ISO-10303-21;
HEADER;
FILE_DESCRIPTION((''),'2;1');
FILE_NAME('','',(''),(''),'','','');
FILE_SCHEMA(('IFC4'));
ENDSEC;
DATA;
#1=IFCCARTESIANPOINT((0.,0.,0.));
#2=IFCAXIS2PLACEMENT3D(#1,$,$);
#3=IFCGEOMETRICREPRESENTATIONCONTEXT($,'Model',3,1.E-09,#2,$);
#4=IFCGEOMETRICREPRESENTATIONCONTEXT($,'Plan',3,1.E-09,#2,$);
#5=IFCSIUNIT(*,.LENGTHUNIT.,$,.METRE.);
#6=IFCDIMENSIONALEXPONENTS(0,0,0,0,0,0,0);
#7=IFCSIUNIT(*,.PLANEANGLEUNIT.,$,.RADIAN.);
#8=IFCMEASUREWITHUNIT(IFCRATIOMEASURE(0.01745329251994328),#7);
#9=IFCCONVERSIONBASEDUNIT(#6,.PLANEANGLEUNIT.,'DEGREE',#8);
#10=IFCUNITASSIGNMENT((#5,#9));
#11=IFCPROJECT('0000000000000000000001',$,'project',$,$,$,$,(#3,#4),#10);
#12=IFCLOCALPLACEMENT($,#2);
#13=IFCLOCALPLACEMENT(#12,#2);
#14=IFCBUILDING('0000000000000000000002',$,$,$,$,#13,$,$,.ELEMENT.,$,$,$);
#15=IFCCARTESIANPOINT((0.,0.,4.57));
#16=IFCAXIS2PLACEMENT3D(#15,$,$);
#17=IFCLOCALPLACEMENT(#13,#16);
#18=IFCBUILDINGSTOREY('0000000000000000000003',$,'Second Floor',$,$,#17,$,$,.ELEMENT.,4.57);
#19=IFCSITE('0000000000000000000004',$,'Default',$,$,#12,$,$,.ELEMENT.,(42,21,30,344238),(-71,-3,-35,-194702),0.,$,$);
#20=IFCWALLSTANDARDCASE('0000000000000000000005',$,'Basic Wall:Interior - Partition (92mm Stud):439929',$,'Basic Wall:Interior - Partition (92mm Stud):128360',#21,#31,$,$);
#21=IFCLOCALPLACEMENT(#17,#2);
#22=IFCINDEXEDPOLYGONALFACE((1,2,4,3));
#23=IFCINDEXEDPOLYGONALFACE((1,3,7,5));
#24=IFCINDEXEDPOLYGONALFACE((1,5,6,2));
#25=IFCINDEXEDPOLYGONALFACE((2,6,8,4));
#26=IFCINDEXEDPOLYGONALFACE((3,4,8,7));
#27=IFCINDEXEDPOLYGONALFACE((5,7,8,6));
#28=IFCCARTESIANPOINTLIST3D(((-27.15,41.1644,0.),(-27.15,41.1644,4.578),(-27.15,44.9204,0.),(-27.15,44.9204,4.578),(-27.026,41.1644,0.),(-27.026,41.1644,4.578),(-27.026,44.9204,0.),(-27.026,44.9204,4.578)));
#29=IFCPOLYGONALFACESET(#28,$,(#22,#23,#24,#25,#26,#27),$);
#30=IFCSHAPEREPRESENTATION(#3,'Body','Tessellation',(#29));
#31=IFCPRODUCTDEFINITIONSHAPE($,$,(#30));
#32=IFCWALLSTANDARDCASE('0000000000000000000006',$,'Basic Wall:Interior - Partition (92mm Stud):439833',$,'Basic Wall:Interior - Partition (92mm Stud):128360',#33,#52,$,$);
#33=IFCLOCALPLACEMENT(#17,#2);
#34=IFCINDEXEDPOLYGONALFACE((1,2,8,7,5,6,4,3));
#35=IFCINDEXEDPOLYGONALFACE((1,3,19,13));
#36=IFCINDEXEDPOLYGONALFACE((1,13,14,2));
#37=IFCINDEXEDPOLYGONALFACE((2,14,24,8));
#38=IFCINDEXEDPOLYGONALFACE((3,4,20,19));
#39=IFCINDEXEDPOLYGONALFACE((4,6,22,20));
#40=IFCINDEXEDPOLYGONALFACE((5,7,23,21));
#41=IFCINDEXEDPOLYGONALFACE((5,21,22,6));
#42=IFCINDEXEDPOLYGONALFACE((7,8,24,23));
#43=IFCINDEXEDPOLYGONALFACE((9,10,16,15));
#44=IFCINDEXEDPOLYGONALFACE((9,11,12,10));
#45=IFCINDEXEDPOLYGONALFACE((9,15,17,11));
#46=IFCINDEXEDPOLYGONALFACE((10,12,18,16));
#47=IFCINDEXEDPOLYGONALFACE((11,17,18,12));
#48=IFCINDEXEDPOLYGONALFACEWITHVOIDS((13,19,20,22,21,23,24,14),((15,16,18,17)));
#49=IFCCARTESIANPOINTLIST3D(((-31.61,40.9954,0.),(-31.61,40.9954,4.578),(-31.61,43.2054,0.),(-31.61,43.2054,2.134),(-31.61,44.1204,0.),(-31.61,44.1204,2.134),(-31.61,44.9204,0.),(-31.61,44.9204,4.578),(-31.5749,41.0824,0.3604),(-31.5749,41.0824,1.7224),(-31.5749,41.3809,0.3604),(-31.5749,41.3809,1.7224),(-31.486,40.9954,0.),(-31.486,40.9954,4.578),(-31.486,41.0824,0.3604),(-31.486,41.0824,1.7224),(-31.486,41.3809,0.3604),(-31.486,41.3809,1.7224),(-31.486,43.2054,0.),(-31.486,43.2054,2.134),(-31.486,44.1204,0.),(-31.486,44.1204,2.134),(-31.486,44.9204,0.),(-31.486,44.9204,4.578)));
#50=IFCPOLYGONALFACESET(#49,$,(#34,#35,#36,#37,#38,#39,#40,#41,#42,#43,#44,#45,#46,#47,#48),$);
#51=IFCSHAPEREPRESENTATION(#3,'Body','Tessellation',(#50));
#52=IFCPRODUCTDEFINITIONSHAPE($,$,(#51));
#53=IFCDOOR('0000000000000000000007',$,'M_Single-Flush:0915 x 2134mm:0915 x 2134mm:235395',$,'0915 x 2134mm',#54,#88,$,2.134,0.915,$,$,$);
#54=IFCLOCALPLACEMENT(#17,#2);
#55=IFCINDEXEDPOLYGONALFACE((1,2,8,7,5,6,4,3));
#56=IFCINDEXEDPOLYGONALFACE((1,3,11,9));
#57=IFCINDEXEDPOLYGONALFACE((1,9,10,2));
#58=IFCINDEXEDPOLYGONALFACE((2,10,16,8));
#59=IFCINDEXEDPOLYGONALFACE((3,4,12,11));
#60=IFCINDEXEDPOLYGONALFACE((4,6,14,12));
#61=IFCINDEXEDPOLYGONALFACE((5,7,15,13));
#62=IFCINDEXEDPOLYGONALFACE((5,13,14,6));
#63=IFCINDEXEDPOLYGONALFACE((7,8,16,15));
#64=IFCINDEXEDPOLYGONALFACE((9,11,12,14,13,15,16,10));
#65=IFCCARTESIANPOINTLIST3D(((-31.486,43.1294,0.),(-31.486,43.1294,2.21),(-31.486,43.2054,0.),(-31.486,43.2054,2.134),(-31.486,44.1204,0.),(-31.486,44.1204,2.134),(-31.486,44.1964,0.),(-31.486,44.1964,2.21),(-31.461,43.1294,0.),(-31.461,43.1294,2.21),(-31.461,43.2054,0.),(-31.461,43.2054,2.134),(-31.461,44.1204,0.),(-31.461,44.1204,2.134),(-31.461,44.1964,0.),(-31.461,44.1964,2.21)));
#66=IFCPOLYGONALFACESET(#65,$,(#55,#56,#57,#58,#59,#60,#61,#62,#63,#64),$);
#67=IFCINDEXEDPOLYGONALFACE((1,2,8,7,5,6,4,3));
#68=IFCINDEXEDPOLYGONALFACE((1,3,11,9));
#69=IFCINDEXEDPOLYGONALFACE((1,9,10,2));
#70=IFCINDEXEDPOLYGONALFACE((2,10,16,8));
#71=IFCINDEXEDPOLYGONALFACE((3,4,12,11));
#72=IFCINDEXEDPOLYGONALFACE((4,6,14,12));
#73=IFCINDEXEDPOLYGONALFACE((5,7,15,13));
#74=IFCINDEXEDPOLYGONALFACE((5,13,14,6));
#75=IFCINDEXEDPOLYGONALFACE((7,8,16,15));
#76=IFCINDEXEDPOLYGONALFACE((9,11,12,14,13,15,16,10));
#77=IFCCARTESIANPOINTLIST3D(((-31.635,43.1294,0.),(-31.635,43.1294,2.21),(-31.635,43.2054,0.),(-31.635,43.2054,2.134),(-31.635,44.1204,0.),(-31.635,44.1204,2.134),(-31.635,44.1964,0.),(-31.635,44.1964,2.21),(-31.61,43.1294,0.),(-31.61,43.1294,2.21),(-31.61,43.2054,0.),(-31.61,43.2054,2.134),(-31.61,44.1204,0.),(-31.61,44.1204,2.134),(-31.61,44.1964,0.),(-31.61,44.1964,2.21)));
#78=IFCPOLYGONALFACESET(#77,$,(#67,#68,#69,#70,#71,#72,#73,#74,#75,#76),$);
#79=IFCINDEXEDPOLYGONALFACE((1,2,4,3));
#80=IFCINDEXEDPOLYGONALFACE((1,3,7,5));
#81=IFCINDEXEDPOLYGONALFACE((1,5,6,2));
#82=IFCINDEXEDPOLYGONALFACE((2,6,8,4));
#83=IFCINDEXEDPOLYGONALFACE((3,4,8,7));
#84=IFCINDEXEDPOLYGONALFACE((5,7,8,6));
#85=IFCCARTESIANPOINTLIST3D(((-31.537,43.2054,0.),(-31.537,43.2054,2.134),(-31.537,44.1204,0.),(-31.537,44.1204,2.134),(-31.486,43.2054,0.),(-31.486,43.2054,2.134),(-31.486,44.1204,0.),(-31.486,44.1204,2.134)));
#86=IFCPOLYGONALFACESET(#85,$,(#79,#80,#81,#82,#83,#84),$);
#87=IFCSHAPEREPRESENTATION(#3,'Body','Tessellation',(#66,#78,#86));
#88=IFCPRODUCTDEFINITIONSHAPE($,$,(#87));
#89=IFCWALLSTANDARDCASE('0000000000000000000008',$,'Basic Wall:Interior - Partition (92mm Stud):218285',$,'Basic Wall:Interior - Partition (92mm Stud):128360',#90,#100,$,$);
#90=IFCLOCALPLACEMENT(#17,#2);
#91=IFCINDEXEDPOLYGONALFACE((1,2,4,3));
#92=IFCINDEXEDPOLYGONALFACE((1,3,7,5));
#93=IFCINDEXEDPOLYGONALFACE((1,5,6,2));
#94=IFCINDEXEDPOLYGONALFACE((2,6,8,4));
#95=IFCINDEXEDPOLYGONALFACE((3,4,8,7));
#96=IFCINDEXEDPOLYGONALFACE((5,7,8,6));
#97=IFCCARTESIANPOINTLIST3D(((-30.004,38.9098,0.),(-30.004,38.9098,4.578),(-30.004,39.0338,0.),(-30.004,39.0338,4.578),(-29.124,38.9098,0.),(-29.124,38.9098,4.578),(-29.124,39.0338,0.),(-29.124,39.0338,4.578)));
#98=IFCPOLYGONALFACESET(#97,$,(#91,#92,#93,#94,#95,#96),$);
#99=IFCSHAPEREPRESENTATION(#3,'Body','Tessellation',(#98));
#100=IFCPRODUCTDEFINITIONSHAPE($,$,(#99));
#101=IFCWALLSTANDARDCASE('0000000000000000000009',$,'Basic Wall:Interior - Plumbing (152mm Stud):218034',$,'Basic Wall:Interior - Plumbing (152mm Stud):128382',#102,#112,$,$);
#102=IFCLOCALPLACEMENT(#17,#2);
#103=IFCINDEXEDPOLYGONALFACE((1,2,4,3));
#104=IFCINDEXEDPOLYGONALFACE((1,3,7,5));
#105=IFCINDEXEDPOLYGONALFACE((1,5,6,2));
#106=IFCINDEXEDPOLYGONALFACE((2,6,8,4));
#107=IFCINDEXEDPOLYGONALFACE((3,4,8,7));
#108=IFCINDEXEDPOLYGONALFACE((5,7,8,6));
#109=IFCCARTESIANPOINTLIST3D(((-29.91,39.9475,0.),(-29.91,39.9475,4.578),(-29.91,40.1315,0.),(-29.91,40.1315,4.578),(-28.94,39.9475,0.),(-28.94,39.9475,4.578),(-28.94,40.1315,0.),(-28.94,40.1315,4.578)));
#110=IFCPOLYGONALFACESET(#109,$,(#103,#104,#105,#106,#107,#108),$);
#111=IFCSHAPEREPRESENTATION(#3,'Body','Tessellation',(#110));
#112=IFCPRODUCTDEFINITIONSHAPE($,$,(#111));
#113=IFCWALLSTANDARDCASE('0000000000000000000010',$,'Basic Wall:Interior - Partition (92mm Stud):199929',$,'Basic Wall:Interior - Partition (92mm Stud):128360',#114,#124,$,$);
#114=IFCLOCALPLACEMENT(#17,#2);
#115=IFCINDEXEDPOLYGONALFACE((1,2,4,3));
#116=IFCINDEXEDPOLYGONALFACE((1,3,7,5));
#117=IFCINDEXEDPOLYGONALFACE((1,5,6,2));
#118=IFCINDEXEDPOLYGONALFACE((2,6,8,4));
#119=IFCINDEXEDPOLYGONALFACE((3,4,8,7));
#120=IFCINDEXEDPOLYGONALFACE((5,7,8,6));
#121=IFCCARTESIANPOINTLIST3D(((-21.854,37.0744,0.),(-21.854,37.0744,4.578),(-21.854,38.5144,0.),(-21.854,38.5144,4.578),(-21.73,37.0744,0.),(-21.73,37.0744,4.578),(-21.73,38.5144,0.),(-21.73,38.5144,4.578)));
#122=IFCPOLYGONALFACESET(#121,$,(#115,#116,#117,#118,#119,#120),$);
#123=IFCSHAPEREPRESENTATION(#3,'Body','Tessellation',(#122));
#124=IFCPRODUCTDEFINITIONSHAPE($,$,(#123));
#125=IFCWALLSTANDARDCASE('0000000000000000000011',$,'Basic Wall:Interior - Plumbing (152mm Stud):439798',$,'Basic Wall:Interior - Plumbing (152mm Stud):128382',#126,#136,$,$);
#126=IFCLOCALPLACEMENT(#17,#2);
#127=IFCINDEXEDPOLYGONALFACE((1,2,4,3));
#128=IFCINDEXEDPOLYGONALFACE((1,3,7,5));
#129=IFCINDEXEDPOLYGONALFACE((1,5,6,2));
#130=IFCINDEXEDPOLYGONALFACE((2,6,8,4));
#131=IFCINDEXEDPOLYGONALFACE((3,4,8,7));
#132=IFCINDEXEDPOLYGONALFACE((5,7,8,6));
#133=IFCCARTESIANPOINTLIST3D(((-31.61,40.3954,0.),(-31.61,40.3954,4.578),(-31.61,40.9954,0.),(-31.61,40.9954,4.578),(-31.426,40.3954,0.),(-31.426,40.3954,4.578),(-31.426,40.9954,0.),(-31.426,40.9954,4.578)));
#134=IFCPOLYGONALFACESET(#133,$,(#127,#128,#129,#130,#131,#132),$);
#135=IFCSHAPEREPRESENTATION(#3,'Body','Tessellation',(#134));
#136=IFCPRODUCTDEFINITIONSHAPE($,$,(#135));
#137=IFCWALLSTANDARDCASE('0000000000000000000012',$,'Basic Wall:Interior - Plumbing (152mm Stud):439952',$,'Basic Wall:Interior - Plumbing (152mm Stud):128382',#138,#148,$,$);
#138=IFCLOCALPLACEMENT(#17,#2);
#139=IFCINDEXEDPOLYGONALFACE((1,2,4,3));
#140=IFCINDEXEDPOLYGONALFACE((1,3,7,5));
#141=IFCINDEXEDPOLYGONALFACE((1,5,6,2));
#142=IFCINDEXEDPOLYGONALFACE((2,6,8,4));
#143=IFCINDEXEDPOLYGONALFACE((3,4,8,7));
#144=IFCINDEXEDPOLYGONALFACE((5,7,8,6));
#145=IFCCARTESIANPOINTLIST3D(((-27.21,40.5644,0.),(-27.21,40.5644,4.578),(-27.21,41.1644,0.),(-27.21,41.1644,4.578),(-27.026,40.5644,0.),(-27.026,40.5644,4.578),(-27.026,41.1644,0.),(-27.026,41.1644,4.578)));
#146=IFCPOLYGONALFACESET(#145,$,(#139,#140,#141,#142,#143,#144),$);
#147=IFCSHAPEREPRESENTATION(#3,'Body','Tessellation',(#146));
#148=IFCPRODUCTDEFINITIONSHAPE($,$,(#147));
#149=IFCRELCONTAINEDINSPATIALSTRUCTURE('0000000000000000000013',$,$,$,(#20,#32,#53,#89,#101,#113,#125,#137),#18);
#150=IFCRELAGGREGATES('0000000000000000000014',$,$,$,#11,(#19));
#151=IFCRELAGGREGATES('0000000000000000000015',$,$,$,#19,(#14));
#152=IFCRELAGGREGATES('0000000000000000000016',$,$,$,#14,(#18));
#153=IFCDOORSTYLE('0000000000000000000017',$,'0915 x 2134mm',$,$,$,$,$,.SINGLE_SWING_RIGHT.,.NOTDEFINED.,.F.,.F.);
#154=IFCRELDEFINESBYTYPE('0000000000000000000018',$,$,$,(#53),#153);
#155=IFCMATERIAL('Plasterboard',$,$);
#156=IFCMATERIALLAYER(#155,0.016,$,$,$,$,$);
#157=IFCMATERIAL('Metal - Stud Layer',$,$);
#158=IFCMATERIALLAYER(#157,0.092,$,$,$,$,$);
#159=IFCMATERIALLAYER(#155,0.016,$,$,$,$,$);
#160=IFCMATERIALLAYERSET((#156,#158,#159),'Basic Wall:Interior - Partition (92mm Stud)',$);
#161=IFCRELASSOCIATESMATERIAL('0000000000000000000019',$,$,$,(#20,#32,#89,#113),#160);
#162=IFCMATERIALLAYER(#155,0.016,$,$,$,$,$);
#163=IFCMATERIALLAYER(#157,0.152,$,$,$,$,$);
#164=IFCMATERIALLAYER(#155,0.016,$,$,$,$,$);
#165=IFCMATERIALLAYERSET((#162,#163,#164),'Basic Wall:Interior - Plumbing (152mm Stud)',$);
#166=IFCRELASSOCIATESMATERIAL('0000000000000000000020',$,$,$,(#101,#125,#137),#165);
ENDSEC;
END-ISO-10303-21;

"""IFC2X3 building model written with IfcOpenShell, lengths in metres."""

from ifc_helpers import new_model, entity, si_unit, converted_unit, frame, frame_2d, origin, origin_2d_with_axis, place, context, project, spatial, polyline, rectangle, outline, extrude, source, transform, mapped, material, layer, layer_set, layer_usage, type_object, type_shapes, element, fill, save


model = new_model("IFC2X3")

# Units and contexts
model_context = context("Model", 3, precision=1e-09, world=origin())
plan_context = context("Plan", 3, precision=1e-09, world=origin())
ifc_project = project(units=[si_unit("LENGTHUNIT", "METRE"), converted_unit("PLANEANGLEUNIT", "DEGREE", entity("IfcRatioMeasure", 0.01745329251994328), si_unit("PLANEANGLEUNIT", "RADIAN"), dimensions=[0, 0, 0, 0, 0, 0, 0])], contexts=[model_context, plan_context])

# Site, building, storey
site_placement = place(None, origin())
site = spatial("IfcSite", under=ifc_project, at=site_placement, Name="Default", CompositionType="ELEMENT", RefLatitude=(42, 21, 30, 344238), RefLongitude=(-71, -3, -35, -194702), RefElevation=0.0)
building_placement = place(site_placement, origin())
building = spatial("IfcBuilding", under=site, at=building_placement, CompositionType="ELEMENT")
storey_placement = place(building_placement, frame((0.0, 0.0, 4.57)))
storey = spatial("IfcBuildingStorey", under=building, at=storey_placement, Name="Second Floor", CompositionType="ELEMENT", Elevation=4.57)

# Wall
ifc_material_1 = material(Name="Plasterboard")
ifc_layer_1 = layer(ifc_material_1, 0.016)
ifc_material_2 = material(Name="Metal - Stud Layer")
ifc_layer_2 = layer(ifc_material_2, 0.092)
ifc_layer_3 = layer(ifc_material_1, 0.016)
ifc_layer_set_1 = layer_set([ifc_layer_1, ifc_layer_2, ifc_layer_3], Name="Basic Wall:Interior - Partition (92mm Stud)")
ifc_layer_usage_1 = layer_usage(ifc_layer_set_1, "AXIS2", "NEGATIVE", 0.062)
wall_1_placement = place(storey_placement, frame((-27.088, 41.1644, 0.0), z_axis=(0.0, 0.0, 1.0), x_axis=(0.0, 1.0, 0.0)))
element("IfcWallStandardCase", 1, at=wall_1_placement, inside=storey, material=ifc_layer_usage_1, Name="Basic Wall:Interior - Partition (92mm Stud):439929", ObjectType="Basic Wall:Interior - Partition (92mm Stud):128360", context=model_context, shape_type="SweptSolid", body=[
    extrude(rectangle(XDim=3.756, YDim=0.124, at=frame_2d((1.878, 0.0), x_axis=(-1.0, 0.0))), origin(), (0.0, 0.0, 1.0), 4.578),
])

# Wall, openings, door
wall_2_placement = place(storey_placement, frame((-31.548, 40.9954, 0.0), z_axis=(0.0, 0.0, 1.0), x_axis=(0.0, 1.0, 0.0)))
wall_2 = element("IfcWallStandardCase", 2, at=wall_2_placement, inside=storey, material=ifc_layer_usage_1, Name="Basic Wall:Interior - Partition (92mm Stud):439833", ObjectType="Basic Wall:Interior - Partition (92mm Stud):128360", context=model_context, shape_type="SweptSolid", body=[
    extrude(rectangle(XDim=3.9251, YDim=0.124, at=frame_2d((1.9625, 0.0), x_axis=(-1.0, 0.0))), origin(), (0.0, 0.0, 1.0), 4.578),
])
opening_1_placement = place(wall_2_placement, origin())
element("IfcOpeningElement", 3, at=opening_1_placement, cuts=wall_2, ObjectType="Opening", context=model_context, shape_type="SweptSolid", body=[
    extrude(rectangle(XDim=1.3621, YDim=0.2984, at=origin_2d_with_axis()), frame((0.2363, -0.1255, 1.0414), z_axis=(0.0, 1.0, 0.0), x_axis=(0.0, 0.0, -1.0)), (0.0, 0.0, 1.0), 0.1524),
])
opening_2_placement = place(wall_2_placement, frame((3.1251, 0.062, 0.0)))
opening_2 = element("IfcOpeningElement", 4, at=opening_2_placement, cuts=wall_2, ObjectType="Opening", context=model_context, shape_type="SweptSolid", body=[
    extrude(rectangle(XDim=0.915, YDim=2.134, at=frame_2d((1.067, 0.4575), x_axis=(0.0, 1.0))), frame((0.0, 0.0, 0.0), z_axis=(0.0, -1.0, 0.0), x_axis=(0.0, 0.0, 1.0)), (0.0, 0.0, 1.0), 0.124),
])
door_style_1 = type_object("IfcDoorStyle", Name="0915 x 2134mm", ConstructionType="NOTDEFINED", OperationType="SINGLE_SWING_RIGHT", ParameterTakesPrecedence=False, Sizeable=False)
shared_shape_1 = source(origin(), model_context, "Body", "SweptSolid", [
    extrude(outline(polyline([(-0.5335, -1.124), (0.5335, -1.124), (0.5335, 1.086), (0.4575, 1.086), (0.4575, -1.048), (-0.4575, -1.048), (-0.4575, 1.086), (-0.5335, 1.086), (-0.5335, -1.124)])), frame((0.4575, 0.124, 1.086), z_axis=(0.0, 1.0, 0.0), x_axis=(1.0, 0.0, 0.0)), (0.0, 0.0, 1.0), 0.025),
    extrude(outline(polyline([(-1.124, -0.5335), (1.086, -0.5335), (1.086, -0.4575), (-1.048, -0.4575), (-1.048, 0.4575), (1.086, 0.4575), (1.086, 0.5335), (-1.124, 0.5335), (-1.124, -0.5335)])), frame((0.4575, -0.025, 1.086), z_axis=(0.0, 1.0, 0.0), x_axis=(0.0, 0.0, -1.0)), (0.0, 0.0, 1.0), 0.025),
    extrude(rectangle(XDim=0.051, YDim=0.915, at=origin_2d_with_axis()), frame((0.4575, 0.0985, 0.0), z_axis=(0.0, 0.0, 1.0), x_axis=(0.0, 1.0, 0.0)), (0.0, 0.0, 1.0), 2.134),
])
type_shapes(door_style_1, [shared_shape_1])
door_1_placement = place(opening_2_placement, frame((0.0, 0.0, 0.0), z_axis=(0.0, 0.0, 1.0), x_axis=(-1.0, 0.0, 0.0)))
door_1 = element("IfcDoor", 5, at=door_1_placement, inside=storey, type_object=door_style_1, Name="M_Single-Flush:0915 x 2134mm:0915 x 2134mm:235395", ObjectType="0915 x 2134mm", OverallHeight=2.134, OverallWidth=0.915, context=model_context, shape_type="MappedRepresentation", body=[
    mapped(shared_shape_1, transform((0.0, 0.0, 0.0), scale=1.0)),
])
fill(opening_2, door_1)

# Walls
wall_3_placement = place(storey_placement, frame((-29.124, 38.9718, 0.0), z_axis=(0.0, 0.0, 1.0), x_axis=(-1.0, 0.0, 0.0)))
element("IfcWallStandardCase", 6, at=wall_3_placement, inside=storey, material=ifc_layer_usage_1, Name="Basic Wall:Interior - Partition (92mm Stud):218285", ObjectType="Basic Wall:Interior - Partition (92mm Stud):128360", context=model_context, shape_type="SweptSolid", body=[
    extrude(rectangle(XDim=0.88, YDim=0.124, at=frame_2d((0.44, 0.0), x_axis=(-1.0, 0.0))), origin(), (0.0, 0.0, 1.0), 4.578),
])
ifc_layer_4 = layer(ifc_material_1, 0.016)
ifc_layer_5 = layer(ifc_material_2, 0.152)
ifc_layer_6 = layer(ifc_material_1, 0.016)
ifc_layer_set_2 = layer_set([ifc_layer_4, ifc_layer_5, ifc_layer_6], Name="Basic Wall:Interior - Plumbing (152mm Stud)")
ifc_layer_usage_2 = layer_usage(ifc_layer_set_2, "AXIS2", "NEGATIVE", 0.092)
wall_4_placement = place(storey_placement, frame((-29.91, 40.0395, 0.0)))
element("IfcWallStandardCase", 7, at=wall_4_placement, inside=storey, material=ifc_layer_usage_2, Name="Basic Wall:Interior - Plumbing (152mm Stud):218034", ObjectType="Basic Wall:Interior - Plumbing (152mm Stud):128382", context=model_context, shape_type="SweptSolid", body=[
    extrude(rectangle(XDim=0.97, YDim=0.184, at=frame_2d((0.485, 0.0), x_axis=(-1.0, 0.0))), origin(), (0.0, 0.0, 1.0), 4.578),
])
wall_5_placement = place(storey_placement, frame((-21.792, 38.5144, 0.0), z_axis=(0.0, 0.0, 1.0), x_axis=(0.0, -1.0, 0.0)))
element("IfcWallStandardCase", 8, at=wall_5_placement, inside=storey, material=ifc_layer_usage_1, Name="Basic Wall:Interior - Partition (92mm Stud):199929", ObjectType="Basic Wall:Interior - Partition (92mm Stud):128360", context=model_context, shape_type="SweptSolid", body=[
    extrude(rectangle(XDim=1.4399, YDim=0.124, at=frame_2d((0.72, 0.0), x_axis=(-1.0, 0.0))), origin(), (0.0, 0.0, 1.0), 4.578),
])
for number, where, z_axis, x_axis, name in (
    (9, (-31.518, 40.3954, 0.0), (0.0, 0.0, 1.0), (0.0, 1.0, 0.0), "Basic Wall:Interior - Plumbing (152mm Stud):439798"),
    (10, (-27.118, 40.5644, 0.0), (0.0, 0.0, 1.0), (0.0, 1.0, 0.0), "Basic Wall:Interior - Plumbing (152mm Stud):439952"),
):
    element("IfcWallStandardCase", number, at=place(storey_placement, frame(where, z_axis=z_axis, x_axis=x_axis)), inside=storey, material=ifc_layer_usage_2, Name=name, ObjectType="Basic Wall:Interior - Plumbing (152mm Stud):128382", context=model_context, shape_type="SweptSolid", body=[
        extrude(rectangle(XDim=0.6, YDim=0.184, at=frame_2d((0.3, 0.0), x_axis=(-1.0, 0.0))), origin(), (0.0, 0.0, 1.0), 4.578),
    ])

save(model, "model.ifc")
